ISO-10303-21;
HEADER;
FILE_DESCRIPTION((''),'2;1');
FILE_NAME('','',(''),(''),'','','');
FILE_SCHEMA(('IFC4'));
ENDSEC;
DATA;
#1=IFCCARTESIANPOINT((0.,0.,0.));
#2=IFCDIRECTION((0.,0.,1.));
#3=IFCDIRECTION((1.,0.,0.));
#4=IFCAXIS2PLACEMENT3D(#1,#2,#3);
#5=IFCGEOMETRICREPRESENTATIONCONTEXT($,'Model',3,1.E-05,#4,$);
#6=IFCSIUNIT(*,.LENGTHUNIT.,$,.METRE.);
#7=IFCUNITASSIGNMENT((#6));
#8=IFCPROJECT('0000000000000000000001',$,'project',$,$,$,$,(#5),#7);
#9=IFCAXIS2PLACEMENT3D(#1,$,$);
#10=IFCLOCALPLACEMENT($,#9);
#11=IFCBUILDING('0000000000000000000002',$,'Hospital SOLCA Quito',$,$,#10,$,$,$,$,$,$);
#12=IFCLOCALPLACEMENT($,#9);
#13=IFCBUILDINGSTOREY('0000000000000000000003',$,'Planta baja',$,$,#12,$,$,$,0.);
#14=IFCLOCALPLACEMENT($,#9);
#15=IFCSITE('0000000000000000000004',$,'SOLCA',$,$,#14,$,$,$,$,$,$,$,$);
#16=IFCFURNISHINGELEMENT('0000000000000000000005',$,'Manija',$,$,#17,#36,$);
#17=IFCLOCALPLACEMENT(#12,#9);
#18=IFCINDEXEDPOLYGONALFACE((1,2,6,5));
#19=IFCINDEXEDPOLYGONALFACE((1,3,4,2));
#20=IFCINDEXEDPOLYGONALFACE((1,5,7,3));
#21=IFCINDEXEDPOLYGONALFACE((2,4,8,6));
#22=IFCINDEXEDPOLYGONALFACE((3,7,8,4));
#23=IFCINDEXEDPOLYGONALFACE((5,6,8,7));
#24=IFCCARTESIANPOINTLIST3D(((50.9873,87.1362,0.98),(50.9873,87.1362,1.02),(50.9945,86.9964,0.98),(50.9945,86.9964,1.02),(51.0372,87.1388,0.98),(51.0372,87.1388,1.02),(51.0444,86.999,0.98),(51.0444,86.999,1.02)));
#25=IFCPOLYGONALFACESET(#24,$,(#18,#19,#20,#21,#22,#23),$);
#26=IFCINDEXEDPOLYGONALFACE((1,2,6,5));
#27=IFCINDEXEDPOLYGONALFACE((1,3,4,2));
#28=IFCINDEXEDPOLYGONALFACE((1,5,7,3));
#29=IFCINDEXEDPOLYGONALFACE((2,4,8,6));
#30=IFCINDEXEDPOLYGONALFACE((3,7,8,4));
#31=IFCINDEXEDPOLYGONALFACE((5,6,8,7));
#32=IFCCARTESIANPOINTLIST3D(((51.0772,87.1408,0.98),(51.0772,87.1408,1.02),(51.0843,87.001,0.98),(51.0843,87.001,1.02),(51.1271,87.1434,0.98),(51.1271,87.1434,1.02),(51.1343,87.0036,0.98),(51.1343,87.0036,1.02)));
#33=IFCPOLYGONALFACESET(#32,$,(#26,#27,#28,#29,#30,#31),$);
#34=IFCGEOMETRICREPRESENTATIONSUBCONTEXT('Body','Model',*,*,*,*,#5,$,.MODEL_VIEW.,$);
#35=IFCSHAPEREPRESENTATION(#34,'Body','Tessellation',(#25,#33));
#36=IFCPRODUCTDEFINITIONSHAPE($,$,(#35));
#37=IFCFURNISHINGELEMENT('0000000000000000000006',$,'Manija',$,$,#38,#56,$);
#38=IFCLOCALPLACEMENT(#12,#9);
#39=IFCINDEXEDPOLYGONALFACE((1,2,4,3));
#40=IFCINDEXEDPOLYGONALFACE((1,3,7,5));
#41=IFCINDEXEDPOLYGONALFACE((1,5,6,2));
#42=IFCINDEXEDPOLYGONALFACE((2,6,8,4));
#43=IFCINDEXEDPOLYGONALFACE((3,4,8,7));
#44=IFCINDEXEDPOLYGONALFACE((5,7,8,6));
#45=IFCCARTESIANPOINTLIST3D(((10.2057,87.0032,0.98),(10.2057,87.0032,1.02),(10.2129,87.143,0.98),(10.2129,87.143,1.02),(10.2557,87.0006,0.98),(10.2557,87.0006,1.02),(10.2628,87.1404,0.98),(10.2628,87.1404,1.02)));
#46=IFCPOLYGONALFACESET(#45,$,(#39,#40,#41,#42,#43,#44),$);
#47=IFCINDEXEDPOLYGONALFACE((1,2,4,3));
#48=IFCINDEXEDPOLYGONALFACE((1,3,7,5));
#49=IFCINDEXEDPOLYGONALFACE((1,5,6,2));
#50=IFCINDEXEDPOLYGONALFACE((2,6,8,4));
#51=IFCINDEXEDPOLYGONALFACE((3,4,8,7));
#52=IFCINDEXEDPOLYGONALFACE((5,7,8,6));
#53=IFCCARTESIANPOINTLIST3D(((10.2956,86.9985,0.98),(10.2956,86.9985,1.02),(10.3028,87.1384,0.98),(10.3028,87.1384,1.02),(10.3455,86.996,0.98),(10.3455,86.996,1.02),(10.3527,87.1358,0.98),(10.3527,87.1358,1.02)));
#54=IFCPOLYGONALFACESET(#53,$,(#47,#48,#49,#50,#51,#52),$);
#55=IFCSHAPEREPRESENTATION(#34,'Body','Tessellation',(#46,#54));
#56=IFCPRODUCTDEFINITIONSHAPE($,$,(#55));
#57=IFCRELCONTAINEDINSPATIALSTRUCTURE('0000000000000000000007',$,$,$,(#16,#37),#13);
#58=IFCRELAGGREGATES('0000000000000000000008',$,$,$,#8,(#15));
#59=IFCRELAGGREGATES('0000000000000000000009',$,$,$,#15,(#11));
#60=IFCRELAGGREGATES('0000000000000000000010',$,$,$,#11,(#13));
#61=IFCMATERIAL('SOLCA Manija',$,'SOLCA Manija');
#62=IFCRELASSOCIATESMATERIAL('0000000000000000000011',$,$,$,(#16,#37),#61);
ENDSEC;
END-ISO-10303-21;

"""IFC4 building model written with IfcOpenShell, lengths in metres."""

from ifc_helpers import new_model, si_unit, frame, origin, origin_with_axes, place, context, subcontext, project, spatial, polyline, outline, extrude, material, element, save


model = new_model("IFC4")

# Units and contexts
model_context = context("Model", 3, precision=1e-05, world=origin_with_axes())
body_context = subcontext(model_context, "Body", "Model", "MODEL_VIEW")
ifc_project = project(units=[si_unit("LENGTHUNIT", "METRE")], contexts=[model_context])

# Site, building, storey
site_placement = place(None, origin())
site = spatial("IfcSite", under=ifc_project, at=site_placement, Name="SOLCA")
building_placement = place(None, origin())
building = spatial("IfcBuilding", under=site, at=building_placement, Name="Hospital SOLCA Quito")
storey_placement = place(None, origin())
storey = spatial("IfcBuildingStorey", under=building, at=storey_placement, Name="Planta baja", Elevation=0.0)

# Furnishing elements
ifc_material_1 = material(Name="SOLCA Manija", Category="SOLCA Manija")
furnishing_1_placement = place(storey_placement, origin_with_axes())
element("IfcFurnishingElement", 1, at=furnishing_1_placement, inside=storey, material=ifc_material_1, Name="Manija", context=body_context, shape_type="SweptSolid", body=[
    extrude(outline(polyline([(50.9873, 87.1362), (50.9945, 86.9964), (51.0444, 86.999), (51.0372, 87.1388), (50.9873, 87.1362)])), frame((0.0, 0.0, 0.98), z_axis=(0.0, 0.0, 1.0), x_axis=(1.0, 0.0, 0.0)), (0.0, 0.0, 1.0), 0.04),
    extrude(outline(polyline([(51.0772, 87.1408), (51.0843, 87.001), (51.1343, 87.0036), (51.1271, 87.1434), (51.0772, 87.1408)])), frame((0.0, 0.0, 0.98), z_axis=(0.0, 0.0, 1.0), x_axis=(1.0, 0.0, 0.0)), (0.0, 0.0, 1.0), 0.04),
])
furnishing_2_placement = place(storey_placement, origin_with_axes())
element("IfcFurnishingElement", 2, at=furnishing_2_placement, inside=storey, material=ifc_material_1, Name="Manija", context=body_context, shape_type="SweptSolid", body=[
    extrude(outline(polyline([(10.2129, 87.143), (10.2057, 87.0032), (10.2557, 87.0006), (10.2628, 87.1404), (10.2129, 87.143)])), frame((0.0, 0.0, 0.98), z_axis=(0.0, 0.0, 1.0), x_axis=(1.0, 0.0, 0.0)), (0.0, 0.0, 1.0), 0.04),
    extrude(outline(polyline([(10.3028, 87.1384), (10.2956, 86.9985), (10.3455, 86.996), (10.3527, 87.1358), (10.3028, 87.1384)])), frame((0.0, 0.0, 0.98), z_axis=(0.0, 0.0, 1.0), x_axis=(1.0, 0.0, 0.0)), (0.0, 0.0, 1.0), 0.04),
])

save(model, "model.ifc")
